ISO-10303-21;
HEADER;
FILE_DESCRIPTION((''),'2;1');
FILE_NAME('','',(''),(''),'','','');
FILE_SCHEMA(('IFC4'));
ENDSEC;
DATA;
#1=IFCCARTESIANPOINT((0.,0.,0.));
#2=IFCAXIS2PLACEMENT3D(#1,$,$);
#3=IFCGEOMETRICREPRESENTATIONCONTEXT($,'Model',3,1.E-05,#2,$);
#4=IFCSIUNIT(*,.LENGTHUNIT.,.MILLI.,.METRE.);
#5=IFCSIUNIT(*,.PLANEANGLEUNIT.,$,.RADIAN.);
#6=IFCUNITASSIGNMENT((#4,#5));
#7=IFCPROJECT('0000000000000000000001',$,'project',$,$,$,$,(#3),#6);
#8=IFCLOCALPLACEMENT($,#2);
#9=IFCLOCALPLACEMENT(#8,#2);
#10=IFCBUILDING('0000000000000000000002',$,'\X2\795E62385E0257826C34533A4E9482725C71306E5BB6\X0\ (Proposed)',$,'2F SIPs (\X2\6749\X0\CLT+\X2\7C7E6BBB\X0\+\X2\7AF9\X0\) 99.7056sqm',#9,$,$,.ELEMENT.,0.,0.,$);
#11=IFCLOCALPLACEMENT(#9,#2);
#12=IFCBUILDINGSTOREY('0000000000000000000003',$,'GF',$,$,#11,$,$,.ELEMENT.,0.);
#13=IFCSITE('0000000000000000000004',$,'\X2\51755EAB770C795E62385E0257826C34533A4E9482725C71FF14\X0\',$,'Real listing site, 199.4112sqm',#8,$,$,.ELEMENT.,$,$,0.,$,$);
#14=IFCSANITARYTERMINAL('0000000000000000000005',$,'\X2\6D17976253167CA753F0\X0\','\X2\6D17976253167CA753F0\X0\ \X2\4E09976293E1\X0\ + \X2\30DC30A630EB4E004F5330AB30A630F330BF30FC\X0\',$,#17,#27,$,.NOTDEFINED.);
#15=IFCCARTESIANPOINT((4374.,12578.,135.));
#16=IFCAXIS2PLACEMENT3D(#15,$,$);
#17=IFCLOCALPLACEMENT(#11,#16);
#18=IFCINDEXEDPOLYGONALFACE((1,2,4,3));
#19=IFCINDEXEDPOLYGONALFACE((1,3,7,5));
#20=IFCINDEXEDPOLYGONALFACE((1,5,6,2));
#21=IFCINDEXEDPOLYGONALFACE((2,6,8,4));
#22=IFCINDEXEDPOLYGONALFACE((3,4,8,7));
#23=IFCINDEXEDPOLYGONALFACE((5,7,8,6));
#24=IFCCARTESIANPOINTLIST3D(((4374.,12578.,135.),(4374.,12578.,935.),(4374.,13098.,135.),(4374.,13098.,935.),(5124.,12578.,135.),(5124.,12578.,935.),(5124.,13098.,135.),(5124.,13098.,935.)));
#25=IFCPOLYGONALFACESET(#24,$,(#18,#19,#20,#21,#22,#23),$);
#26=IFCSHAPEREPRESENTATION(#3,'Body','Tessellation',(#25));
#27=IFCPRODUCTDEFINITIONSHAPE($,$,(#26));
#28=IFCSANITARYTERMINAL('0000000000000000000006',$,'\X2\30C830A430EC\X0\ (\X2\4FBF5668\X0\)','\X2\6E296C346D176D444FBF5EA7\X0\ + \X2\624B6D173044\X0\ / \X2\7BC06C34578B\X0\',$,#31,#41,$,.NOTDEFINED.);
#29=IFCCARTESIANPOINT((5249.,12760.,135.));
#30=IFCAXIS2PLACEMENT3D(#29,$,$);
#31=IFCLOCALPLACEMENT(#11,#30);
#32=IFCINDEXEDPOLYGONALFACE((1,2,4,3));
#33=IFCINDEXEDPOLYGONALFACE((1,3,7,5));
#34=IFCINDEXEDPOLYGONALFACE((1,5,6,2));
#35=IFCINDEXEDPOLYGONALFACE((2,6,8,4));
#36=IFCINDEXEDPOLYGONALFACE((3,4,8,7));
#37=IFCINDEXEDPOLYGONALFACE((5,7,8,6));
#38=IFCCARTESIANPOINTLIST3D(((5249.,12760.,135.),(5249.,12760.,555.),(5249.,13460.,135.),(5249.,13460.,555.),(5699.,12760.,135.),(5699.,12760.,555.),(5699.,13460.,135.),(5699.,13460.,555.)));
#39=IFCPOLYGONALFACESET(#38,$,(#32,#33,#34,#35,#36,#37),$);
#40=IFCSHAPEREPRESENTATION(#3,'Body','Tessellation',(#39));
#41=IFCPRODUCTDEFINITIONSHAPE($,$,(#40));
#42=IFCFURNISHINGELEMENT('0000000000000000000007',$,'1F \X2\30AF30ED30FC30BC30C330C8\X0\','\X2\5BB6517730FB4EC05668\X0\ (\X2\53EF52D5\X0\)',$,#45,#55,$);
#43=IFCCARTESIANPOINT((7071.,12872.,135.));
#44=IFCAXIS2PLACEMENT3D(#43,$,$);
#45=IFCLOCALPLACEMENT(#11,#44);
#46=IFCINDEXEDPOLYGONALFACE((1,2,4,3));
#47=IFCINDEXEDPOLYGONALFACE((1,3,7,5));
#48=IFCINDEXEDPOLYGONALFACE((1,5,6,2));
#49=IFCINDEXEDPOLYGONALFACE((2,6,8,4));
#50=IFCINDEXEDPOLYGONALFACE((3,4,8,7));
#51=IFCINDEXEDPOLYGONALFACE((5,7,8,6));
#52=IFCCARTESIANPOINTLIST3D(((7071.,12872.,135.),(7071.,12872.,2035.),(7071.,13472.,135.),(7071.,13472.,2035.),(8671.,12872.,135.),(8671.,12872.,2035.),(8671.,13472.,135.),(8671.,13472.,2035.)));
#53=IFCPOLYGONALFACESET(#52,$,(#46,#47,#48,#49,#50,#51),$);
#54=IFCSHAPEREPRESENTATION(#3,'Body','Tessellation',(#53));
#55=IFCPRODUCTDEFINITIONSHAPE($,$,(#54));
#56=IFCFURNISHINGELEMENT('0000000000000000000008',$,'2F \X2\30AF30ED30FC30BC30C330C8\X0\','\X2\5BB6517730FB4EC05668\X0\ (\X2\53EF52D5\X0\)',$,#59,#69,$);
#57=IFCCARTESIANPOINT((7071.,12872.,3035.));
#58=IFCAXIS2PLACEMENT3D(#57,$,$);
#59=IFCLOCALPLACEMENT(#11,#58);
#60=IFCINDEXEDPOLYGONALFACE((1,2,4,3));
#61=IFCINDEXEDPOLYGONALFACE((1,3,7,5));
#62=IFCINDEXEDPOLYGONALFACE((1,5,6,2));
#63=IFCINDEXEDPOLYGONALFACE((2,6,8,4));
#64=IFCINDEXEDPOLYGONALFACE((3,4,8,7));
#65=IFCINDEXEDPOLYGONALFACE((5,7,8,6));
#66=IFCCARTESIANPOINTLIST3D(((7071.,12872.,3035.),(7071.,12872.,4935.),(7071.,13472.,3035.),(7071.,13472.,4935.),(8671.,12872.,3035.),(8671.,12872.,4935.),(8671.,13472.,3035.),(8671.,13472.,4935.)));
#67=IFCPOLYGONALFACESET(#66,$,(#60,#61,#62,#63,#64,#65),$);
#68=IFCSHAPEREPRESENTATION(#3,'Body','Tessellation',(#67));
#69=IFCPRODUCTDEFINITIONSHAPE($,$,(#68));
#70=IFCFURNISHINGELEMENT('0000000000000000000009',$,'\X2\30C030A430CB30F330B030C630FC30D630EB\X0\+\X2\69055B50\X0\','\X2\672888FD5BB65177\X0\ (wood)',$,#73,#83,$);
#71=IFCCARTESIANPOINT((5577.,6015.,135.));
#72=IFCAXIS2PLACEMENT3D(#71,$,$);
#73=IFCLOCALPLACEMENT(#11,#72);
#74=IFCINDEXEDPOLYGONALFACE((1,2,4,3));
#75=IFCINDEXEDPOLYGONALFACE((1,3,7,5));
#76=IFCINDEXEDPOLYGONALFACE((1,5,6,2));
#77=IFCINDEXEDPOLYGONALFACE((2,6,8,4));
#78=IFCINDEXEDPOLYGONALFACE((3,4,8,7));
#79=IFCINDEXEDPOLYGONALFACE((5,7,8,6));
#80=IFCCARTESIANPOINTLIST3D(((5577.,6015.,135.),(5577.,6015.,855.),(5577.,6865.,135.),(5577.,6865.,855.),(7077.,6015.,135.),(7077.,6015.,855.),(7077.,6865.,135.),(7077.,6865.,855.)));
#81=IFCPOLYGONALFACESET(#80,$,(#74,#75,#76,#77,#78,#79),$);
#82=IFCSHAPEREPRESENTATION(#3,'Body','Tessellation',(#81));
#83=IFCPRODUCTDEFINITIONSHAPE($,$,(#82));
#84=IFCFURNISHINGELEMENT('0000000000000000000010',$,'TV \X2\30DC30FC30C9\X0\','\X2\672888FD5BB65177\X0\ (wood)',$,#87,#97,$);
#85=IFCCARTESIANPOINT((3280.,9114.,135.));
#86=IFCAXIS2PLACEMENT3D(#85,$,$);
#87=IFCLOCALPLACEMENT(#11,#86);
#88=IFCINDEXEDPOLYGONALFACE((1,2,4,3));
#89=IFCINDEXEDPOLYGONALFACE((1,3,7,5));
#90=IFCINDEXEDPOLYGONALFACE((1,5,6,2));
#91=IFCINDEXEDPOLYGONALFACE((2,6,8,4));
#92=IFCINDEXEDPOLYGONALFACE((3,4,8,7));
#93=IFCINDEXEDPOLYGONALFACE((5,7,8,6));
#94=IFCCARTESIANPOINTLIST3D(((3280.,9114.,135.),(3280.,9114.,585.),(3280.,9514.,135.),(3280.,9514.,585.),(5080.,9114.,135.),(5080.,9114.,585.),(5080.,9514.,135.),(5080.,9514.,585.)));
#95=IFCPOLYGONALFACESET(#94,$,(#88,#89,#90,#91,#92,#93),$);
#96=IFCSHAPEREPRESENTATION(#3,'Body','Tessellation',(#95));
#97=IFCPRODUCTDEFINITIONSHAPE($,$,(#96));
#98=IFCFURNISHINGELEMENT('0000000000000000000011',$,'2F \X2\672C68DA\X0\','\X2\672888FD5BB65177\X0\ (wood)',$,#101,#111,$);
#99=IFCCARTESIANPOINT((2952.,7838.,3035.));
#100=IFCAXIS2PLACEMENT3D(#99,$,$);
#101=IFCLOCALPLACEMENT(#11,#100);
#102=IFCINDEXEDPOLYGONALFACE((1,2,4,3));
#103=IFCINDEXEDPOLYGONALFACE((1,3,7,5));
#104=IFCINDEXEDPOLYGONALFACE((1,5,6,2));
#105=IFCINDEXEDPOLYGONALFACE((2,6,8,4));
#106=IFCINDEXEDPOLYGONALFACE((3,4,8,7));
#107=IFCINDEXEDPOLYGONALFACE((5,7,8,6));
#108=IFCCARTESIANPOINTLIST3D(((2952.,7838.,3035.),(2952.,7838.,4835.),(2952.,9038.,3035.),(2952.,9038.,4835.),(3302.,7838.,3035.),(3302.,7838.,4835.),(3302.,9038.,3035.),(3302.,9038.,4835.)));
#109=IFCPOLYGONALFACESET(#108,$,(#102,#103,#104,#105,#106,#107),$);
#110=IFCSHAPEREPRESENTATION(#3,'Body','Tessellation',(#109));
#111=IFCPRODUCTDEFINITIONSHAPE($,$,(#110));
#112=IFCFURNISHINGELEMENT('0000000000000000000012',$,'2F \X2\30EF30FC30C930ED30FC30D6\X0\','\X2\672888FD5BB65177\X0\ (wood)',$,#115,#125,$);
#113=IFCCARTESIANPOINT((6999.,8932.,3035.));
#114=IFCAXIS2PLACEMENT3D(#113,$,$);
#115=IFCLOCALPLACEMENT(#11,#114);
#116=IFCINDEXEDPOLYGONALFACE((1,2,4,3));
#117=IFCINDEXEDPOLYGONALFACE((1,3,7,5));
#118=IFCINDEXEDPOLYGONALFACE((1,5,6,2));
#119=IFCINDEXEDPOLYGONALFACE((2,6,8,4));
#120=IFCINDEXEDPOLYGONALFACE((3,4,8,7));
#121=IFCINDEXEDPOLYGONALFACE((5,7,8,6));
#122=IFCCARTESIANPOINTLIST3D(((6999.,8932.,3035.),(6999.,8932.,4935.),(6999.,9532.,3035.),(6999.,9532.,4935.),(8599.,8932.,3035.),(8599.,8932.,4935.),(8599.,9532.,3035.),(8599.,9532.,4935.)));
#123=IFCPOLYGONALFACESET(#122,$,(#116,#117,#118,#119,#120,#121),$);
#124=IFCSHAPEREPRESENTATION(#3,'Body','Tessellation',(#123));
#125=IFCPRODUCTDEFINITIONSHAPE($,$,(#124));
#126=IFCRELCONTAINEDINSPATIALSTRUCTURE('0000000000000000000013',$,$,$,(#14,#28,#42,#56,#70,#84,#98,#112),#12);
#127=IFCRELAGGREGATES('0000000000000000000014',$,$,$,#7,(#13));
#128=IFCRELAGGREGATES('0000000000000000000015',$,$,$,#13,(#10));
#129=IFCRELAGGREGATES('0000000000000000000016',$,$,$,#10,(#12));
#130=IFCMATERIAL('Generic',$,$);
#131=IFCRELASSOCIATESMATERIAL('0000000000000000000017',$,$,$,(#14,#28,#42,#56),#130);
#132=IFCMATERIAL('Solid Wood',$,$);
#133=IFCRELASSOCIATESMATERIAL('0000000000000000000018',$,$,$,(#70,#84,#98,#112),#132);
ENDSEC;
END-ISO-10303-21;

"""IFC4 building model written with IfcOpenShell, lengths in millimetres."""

from ifc_helpers import new_model, si_unit, frame, frame_2d, origin, place, context, project, spatial, rectangle, extrude, material, element, save


model = new_model("IFC4")

# Units and contexts
model_context = context("Model", 3, precision=1e-05, world=origin())
ifc_project = project(units=[si_unit("LENGTHUNIT", "METRE", prefix="MILLI"), si_unit("PLANEANGLEUNIT", "RADIAN")], contexts=[model_context])

# Site, building, storey
site_placement = place(None, origin())
site = spatial("IfcSite", under=ifc_project, at=site_placement, Name="兵庫県神戸市垂水区五色山４", ObjectType="Real listing site, 199.4112sqm", CompositionType="ELEMENT", RefElevation=0.0)
building_placement = place(site_placement, origin())
building = spatial("IfcBuilding", under=site, at=building_placement, Name="神戸市垂水区五色山の家 (Proposed)", ObjectType="2F SIPs (杉CLT+籾殻+竹) 99.7056sqm", CompositionType="ELEMENT", ElevationOfRefHeight=0.0, ElevationOfTerrain=0.0)
storey_placement = place(building_placement, origin())
storey = spatial("IfcBuildingStorey", under=building, at=storey_placement, Name="GF", CompositionType="ELEMENT", Elevation=0.0)

# Shared definitions
ifc_material_1 = material(Name="Solid Wood")

# Sanitary terminals
ifc_material_2 = material(Name="Generic")
sanitary_terminal_1_placement = place(storey_placement, frame((4374.0, 12578.0, 135.0)))
element("IfcSanitaryTerminal", 1, at=sanitary_terminal_1_placement, inside=storey, material=ifc_material_2, Name="洗面化粧台", Description="洗面化粧台 三面鏡 + ボウル一体カウンター", PredefinedType="NOTDEFINED", context=model_context, shape_type="SweptSolid", body=[
    extrude(rectangle(XDim=750.0, YDim=520.0, at=frame_2d((375.0, 260.0))), frame((4374.0, 12578.0, 135.0)), (0.0, 0.0, 1.0), 800.0),
])
sanitary_terminal_2_placement = place(storey_placement, frame((5249.0, 12760.0, 135.0)))
element("IfcSanitaryTerminal", 2, at=sanitary_terminal_2_placement, inside=storey, material=ifc_material_2, Name="トイレ (便器)", Description="温水洗浄便座 + 手洗い / 節水型", PredefinedType="NOTDEFINED", context=model_context, shape_type="SweptSolid", body=[
    extrude(rectangle(XDim=450.0, YDim=700.0, at=frame_2d((225.0, 350.0))), frame((5249.0, 12760.0, 135.0)), (0.0, 0.0, 1.0), 420.0),
])

# Furnishing elements
furnishing_1_placement = place(storey_placement, frame((7071.0, 12872.0, 135.0)))
element("IfcFurnishingElement", 3, at=furnishing_1_placement, inside=storey, material=ifc_material_2, Name="1F クローゼット", Description="家具・什器 (可動)", context=model_context, shape_type="SweptSolid", body=[
    extrude(rectangle(XDim=1600.0, YDim=600.0, at=frame_2d((800.0, 300.0))), frame((7071.0, 12872.0, 135.0)), (0.0, 0.0, 1.0), 1900.0),
])
furnishing_2_placement = place(storey_placement, frame((7071.0, 12872.0, 3035.0)))
element("IfcFurnishingElement", 4, at=furnishing_2_placement, inside=storey, material=ifc_material_2, Name="2F クローゼット", Description="家具・什器 (可動)", context=model_context, shape_type="SweptSolid", body=[
    extrude(rectangle(XDim=1600.0, YDim=600.0, at=frame_2d((800.0, 300.0))), frame((7071.0, 12872.0, 3035.0)), (0.0, 0.0, 1.0), 1900.0),
])
furnishing_3_placement = place(storey_placement, frame((5577.0, 6015.0, 135.0)))
element("IfcFurnishingElement", 5, at=furnishing_3_placement, inside=storey, material=ifc_material_1, Name="ダイニングテーブル+椅子", Description="木製家具 (wood)", context=model_context, shape_type="SweptSolid", body=[
    extrude(rectangle(XDim=1500.0, YDim=850.0, at=frame_2d((750.0, 425.0))), frame((5577.0, 6015.0, 135.0)), (0.0, 0.0, 1.0), 720.0),
])
furnishing_4_placement = place(storey_placement, frame((3280.0, 9114.0, 135.0)))
element("IfcFurnishingElement", 6, at=furnishing_4_placement, inside=storey, material=ifc_material_1, Name="TV ボード", Description="木製家具 (wood)", context=model_context, shape_type="SweptSolid", body=[
    extrude(rectangle(XDim=1800.0, YDim=400.0, at=frame_2d((900.0, 200.0))), frame((3280.0, 9114.0, 135.0)), (0.0, 0.0, 1.0), 450.0),
])
furnishing_5_placement = place(storey_placement, frame((2952.0, 7838.0, 3035.0)))
element("IfcFurnishingElement", 7, at=furnishing_5_placement, inside=storey, material=ifc_material_1, Name="2F 本棚", Description="木製家具 (wood)", context=model_context, shape_type="SweptSolid", body=[
    extrude(rectangle(XDim=350.0, YDim=1200.0, at=frame_2d((175.0, 600.0))), frame((2952.0, 7838.0, 3035.0)), (0.0, 0.0, 1.0), 1800.0),
])
furnishing_6_placement = place(storey_placement, frame((6999.0, 8932.0, 3035.0)))
element("IfcFurnishingElement", 8, at=furnishing_6_placement, inside=storey, material=ifc_material_1, Name="2F ワードローブ", Description="木製家具 (wood)", context=model_context, shape_type="SweptSolid", body=[
    extrude(rectangle(XDim=1600.0, YDim=600.0, at=frame_2d((800.0, 300.0))), frame((6999.0, 8932.0, 3035.0)), (0.0, 0.0, 1.0), 1900.0),
])

save(model, "model.ifc")
